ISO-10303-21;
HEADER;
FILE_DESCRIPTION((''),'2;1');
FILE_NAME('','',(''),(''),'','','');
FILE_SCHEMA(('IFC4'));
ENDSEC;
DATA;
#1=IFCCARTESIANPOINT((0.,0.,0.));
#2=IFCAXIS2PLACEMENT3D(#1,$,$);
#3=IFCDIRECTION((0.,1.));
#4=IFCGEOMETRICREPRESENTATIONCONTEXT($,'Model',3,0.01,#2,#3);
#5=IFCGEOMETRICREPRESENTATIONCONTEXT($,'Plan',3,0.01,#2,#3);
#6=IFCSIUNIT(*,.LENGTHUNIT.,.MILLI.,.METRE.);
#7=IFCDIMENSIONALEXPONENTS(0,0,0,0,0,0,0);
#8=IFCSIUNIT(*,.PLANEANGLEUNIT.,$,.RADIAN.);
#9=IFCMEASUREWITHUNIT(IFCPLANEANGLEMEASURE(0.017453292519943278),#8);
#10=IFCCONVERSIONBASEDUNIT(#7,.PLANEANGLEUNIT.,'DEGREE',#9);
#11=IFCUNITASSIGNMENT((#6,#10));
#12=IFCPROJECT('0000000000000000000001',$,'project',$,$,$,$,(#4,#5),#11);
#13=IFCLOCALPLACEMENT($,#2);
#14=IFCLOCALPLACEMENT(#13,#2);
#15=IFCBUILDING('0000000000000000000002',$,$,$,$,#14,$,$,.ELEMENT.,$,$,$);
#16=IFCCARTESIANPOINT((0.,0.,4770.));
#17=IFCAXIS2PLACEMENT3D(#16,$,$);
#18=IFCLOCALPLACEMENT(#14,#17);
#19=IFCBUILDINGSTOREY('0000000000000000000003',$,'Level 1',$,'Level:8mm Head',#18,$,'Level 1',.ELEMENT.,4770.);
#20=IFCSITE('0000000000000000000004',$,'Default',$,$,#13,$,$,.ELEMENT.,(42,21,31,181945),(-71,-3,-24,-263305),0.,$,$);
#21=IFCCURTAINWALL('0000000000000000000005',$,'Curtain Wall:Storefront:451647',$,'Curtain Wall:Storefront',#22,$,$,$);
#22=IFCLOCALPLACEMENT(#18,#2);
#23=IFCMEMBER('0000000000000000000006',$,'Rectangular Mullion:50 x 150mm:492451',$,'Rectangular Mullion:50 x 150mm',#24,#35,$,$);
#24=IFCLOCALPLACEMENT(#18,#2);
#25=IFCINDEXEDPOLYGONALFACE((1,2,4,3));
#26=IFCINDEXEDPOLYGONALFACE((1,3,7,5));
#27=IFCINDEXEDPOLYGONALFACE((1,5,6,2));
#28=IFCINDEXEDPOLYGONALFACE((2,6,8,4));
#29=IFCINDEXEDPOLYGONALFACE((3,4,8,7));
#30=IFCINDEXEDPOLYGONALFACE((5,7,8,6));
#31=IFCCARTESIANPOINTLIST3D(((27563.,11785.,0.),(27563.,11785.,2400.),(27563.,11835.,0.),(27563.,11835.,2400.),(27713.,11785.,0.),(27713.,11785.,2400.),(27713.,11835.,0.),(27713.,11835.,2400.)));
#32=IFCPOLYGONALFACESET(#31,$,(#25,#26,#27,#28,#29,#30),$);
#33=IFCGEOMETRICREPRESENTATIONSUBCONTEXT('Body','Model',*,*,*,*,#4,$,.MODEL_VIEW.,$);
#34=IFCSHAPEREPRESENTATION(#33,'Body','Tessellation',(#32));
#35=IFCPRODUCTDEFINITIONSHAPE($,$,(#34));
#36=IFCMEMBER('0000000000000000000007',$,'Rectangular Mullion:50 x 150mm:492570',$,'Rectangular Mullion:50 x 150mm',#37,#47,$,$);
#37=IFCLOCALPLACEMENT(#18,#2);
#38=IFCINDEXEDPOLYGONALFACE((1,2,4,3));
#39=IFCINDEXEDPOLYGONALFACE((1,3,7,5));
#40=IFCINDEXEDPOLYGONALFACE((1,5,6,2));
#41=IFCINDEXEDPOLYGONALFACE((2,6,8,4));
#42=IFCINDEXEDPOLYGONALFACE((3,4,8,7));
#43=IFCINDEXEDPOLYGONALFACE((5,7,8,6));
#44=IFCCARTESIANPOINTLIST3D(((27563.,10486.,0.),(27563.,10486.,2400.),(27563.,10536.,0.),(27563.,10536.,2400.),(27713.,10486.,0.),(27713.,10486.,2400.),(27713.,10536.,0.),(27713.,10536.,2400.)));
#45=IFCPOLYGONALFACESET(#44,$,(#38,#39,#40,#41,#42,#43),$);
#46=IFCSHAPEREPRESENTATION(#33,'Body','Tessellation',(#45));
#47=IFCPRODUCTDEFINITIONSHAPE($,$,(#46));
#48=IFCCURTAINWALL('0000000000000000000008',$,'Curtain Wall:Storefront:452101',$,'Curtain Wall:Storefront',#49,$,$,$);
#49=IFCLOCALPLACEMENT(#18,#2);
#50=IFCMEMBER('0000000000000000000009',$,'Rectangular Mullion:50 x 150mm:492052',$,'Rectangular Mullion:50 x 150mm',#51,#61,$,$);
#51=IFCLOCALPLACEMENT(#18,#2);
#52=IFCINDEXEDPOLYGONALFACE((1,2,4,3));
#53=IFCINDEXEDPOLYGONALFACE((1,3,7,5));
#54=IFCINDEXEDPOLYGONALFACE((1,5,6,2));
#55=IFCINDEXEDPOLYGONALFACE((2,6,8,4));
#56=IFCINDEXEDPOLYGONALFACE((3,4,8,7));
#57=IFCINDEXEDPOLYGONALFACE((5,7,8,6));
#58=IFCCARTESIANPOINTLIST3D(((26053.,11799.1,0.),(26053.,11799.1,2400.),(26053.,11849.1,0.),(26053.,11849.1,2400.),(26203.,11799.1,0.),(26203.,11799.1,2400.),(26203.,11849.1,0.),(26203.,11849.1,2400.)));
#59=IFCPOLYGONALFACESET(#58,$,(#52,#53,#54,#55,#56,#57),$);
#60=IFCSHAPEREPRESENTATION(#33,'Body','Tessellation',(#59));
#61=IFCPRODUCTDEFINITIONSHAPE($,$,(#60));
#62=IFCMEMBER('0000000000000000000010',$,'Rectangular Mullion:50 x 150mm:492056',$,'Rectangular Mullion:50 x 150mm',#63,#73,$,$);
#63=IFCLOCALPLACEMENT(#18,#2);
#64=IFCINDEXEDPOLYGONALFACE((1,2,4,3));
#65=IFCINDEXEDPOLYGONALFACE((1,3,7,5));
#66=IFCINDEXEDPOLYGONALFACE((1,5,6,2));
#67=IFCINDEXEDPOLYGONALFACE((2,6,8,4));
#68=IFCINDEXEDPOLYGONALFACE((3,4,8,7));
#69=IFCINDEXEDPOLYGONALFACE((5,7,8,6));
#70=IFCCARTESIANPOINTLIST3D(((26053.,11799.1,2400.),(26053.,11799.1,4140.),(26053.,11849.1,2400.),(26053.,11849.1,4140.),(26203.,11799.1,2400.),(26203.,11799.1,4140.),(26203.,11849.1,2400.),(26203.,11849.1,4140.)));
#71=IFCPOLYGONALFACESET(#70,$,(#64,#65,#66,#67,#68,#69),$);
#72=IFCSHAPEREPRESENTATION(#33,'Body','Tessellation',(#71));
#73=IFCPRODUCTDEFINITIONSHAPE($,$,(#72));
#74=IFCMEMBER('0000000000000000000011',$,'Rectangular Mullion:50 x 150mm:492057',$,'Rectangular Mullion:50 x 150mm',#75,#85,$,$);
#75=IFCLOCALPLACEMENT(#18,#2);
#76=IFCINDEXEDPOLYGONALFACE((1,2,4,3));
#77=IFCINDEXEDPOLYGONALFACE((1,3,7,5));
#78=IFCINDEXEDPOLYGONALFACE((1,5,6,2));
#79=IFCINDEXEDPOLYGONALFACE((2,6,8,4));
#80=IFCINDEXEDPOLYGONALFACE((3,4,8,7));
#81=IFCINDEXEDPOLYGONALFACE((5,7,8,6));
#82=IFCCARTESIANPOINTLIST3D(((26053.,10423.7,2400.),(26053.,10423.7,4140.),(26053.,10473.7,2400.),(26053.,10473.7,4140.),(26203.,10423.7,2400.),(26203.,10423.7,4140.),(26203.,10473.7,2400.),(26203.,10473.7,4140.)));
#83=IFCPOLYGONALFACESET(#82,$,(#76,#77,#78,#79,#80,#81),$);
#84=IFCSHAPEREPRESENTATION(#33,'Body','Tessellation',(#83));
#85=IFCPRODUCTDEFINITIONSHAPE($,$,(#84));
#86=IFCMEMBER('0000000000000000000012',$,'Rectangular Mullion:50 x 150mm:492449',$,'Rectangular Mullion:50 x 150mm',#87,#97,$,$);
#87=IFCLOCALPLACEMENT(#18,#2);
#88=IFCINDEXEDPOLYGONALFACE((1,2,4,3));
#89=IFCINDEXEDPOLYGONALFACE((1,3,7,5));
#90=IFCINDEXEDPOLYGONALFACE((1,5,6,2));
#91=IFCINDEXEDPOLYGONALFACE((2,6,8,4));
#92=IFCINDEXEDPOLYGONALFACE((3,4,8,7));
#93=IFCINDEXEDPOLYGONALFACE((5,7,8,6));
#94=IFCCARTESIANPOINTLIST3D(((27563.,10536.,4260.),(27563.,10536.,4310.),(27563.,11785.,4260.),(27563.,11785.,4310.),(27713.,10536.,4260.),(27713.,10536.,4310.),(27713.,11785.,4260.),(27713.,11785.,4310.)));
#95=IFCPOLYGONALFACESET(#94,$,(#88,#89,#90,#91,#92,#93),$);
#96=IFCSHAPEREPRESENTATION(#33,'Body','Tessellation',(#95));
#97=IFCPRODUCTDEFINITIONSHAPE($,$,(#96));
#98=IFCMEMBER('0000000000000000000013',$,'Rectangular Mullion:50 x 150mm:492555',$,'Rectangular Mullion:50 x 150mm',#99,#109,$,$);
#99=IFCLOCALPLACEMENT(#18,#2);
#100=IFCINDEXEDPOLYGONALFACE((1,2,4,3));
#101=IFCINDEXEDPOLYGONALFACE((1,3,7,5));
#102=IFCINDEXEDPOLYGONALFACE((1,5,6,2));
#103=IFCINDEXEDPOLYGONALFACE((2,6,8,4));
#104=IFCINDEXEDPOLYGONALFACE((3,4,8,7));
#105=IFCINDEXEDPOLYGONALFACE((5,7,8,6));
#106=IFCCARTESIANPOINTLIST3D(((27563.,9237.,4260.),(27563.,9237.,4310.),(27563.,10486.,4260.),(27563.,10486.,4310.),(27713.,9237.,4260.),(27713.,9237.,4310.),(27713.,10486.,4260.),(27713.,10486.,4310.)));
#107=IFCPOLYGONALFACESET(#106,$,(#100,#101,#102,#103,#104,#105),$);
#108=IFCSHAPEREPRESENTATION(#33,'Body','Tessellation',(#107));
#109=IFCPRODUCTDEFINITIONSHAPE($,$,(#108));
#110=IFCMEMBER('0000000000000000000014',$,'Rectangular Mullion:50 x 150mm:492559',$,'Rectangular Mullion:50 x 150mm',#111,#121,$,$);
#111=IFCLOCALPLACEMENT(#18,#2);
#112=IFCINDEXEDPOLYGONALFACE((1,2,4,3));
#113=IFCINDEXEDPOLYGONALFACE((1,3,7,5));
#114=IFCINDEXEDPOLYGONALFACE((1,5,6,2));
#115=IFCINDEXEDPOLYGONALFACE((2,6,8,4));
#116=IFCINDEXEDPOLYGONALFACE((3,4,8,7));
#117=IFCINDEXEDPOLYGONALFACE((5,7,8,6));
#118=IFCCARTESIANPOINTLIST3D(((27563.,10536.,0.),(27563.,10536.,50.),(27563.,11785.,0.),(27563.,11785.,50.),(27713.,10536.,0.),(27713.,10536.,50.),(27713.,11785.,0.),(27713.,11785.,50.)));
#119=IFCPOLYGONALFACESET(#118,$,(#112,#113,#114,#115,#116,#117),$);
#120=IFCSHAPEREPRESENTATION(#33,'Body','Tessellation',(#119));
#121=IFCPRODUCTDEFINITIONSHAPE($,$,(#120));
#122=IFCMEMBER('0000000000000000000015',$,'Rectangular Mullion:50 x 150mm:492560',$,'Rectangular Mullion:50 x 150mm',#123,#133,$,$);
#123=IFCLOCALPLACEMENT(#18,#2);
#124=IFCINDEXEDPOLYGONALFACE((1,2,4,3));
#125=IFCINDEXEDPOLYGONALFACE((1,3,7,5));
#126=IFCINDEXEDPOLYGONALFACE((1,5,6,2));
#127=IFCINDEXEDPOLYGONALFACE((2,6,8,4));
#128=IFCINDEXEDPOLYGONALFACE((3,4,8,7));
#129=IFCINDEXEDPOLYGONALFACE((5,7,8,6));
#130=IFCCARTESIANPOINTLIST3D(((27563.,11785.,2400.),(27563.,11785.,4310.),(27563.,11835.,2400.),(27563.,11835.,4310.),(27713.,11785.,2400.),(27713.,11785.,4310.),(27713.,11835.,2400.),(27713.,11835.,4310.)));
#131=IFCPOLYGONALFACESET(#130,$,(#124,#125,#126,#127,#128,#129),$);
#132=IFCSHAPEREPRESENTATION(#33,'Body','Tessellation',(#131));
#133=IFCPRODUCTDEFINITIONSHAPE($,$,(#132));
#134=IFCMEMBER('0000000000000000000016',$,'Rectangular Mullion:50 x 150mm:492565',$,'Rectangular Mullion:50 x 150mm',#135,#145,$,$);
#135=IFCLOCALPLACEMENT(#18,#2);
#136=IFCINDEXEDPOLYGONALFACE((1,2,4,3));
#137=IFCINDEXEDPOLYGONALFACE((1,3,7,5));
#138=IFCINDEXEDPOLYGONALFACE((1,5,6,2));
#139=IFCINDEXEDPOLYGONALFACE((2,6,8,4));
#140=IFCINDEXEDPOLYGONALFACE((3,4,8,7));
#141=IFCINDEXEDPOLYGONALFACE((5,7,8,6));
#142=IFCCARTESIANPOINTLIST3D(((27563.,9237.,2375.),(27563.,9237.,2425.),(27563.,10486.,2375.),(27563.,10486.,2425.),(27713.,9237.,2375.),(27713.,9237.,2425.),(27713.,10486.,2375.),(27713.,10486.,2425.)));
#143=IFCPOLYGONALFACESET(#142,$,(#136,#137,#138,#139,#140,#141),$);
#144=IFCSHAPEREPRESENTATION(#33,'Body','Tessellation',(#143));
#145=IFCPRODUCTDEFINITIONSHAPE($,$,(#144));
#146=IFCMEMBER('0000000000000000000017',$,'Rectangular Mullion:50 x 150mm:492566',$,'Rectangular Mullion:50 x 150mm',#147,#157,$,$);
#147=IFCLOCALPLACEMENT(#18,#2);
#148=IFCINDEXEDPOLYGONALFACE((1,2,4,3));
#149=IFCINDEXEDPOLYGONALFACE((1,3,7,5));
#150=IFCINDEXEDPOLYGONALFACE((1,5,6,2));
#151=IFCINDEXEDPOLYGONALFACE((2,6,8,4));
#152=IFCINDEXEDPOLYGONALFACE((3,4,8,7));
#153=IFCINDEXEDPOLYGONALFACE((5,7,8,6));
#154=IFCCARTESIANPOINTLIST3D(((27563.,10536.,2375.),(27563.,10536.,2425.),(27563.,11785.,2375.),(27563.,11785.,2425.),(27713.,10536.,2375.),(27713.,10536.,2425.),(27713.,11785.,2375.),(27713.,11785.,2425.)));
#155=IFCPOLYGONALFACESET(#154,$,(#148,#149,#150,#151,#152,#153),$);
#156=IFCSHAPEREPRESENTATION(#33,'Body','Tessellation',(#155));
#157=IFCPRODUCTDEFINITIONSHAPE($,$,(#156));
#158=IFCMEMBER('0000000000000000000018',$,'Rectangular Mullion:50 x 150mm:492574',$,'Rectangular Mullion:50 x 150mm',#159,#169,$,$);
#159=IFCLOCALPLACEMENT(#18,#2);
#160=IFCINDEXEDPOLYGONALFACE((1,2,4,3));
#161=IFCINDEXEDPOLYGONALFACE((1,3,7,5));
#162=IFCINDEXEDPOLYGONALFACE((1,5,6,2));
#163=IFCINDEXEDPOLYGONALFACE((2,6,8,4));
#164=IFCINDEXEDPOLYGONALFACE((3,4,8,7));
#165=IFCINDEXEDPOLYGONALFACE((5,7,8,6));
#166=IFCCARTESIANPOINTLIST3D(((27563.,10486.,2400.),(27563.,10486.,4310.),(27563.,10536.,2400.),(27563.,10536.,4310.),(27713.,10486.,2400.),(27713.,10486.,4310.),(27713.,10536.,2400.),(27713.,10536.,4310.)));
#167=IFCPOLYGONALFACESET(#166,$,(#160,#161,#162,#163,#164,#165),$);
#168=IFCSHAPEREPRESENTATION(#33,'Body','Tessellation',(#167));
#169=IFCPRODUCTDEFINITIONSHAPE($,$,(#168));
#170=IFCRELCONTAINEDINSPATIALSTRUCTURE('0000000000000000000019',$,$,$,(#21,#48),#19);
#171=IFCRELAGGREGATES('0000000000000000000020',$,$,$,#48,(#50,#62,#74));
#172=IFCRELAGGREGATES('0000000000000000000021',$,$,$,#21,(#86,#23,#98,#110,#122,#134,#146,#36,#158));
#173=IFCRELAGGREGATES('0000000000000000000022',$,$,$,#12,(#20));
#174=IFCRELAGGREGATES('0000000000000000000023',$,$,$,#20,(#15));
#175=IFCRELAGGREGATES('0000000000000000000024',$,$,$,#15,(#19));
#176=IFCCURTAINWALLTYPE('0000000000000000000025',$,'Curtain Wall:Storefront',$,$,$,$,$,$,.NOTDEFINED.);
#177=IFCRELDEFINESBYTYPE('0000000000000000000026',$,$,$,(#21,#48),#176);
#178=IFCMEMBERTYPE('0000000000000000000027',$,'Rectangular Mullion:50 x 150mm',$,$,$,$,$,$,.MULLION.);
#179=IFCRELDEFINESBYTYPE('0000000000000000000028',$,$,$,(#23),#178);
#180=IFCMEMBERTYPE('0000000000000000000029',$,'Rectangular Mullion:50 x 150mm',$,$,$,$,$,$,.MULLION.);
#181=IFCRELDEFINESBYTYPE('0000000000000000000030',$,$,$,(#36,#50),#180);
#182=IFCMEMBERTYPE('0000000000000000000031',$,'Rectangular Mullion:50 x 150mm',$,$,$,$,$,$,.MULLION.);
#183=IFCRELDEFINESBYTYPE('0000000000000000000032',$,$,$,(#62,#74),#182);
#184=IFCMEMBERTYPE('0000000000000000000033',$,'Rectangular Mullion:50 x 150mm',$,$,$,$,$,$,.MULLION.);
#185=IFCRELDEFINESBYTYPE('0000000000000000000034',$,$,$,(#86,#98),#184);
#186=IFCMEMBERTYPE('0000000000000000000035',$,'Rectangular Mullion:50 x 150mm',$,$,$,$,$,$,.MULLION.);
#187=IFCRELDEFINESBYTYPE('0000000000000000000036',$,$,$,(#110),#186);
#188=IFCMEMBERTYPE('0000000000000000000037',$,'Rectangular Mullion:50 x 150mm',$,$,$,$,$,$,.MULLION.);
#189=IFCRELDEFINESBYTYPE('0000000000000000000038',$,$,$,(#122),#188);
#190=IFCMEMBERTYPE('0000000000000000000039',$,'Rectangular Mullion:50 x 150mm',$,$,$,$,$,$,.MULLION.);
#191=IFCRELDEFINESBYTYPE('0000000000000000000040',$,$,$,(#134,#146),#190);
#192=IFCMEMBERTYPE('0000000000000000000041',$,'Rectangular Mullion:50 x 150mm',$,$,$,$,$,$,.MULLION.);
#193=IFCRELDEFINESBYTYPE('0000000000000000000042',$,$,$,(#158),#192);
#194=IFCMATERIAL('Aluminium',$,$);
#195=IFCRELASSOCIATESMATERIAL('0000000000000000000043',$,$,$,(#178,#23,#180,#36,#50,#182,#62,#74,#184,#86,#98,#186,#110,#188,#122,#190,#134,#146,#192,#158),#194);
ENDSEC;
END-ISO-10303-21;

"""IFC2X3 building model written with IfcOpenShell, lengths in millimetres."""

from ifc_helpers import new_model, entity, si_unit, converted_unit, direction, frame, origin, origin_2d_with_axis, place, context, subcontext, project, spatial, rectangle, extrude, source, transform, mapped, material, type_object, type_shapes, element, aggregate, save


model = new_model("IFC2X3")

# Units and contexts
model_context = context("Model", 3, precision=0.01, world=origin(), true_north=direction((0.0, 1.0)))
plan_context = context("Plan", 3, precision=0.01, world=origin(), true_north=direction((0.0, 1.0)))
body_context = subcontext(model_context, "Body", "Model", "MODEL_VIEW")
ifc_project = project(units=[si_unit("LENGTHUNIT", "METRE", prefix="MILLI"), converted_unit("PLANEANGLEUNIT", "DEGREE", entity("IfcPlaneAngleMeasure", 0.017453292519943278), si_unit("PLANEANGLEUNIT", "RADIAN"), dimensions=[0, 0, 0, 0, 0, 0, 0])], contexts=[model_context, plan_context])

# Site, building, storey
site_placement = place(None, origin())
site = spatial("IfcSite", under=ifc_project, at=site_placement, Name="Default", CompositionType="ELEMENT", RefLatitude=(42, 21, 31, 181945), RefLongitude=(-71, -3, -24, -263305), RefElevation=0.0)
building_placement = place(site_placement, origin())
building = spatial("IfcBuilding", under=site, at=building_placement, CompositionType="ELEMENT")
storey_placement = place(building_placement, frame((0.0, 0.0, 4770.0)))
storey = spatial("IfcBuildingStorey", under=building, at=storey_placement, Name="Level 1", ObjectType="Level:8mm Head", LongName="Level 1", CompositionType="ELEMENT", Elevation=4770.0)

# Curtain walls, members
curtain_wall_type = type_object("IfcCurtainWallType", Name="Curtain Wall:Storefront", PredefinedType="NOTDEFINED")
curtain_wall_1_placement = place(storey_placement, frame((0.0, 0.0, -4770.0)))
curtain_wall_1 = element("IfcCurtainWall", 1, at=curtain_wall_1_placement, inside=storey, type_object=curtain_wall_type, Name="Curtain Wall:Storefront:451647", ObjectType="Curtain Wall:Storefront")
ifc_material_1 = material(Name="Aluminium")
member_type_1 = type_object("IfcMemberType", Name="Rectangular Mullion:50 x 150mm", PredefinedType="MULLION", material=ifc_material_1)
shared_shape_1 = source(origin(), body_context, "Body", "SweptSolid", [
    extrude(rectangle(XDim=50.0, YDim=150.0, at=origin_2d_with_axis()), frame((-25.0, 0.0, -2400.0), z_axis=(0.0, 0.0, 1.0), x_axis=(-1.0, 0.0, 0.0)), (0.0, 0.0, 1.0), 2400.0),
])
type_shapes(member_type_1, [shared_shape_1])
member_1_placement = place(curtain_wall_1_placement, frame((27638.0, 11835.0, 4770.0), z_axis=(0.0, 0.0, -1.0), x_axis=(0.0, 1.0, 0.0)))
member_1 = element("IfcMember", 2, at=member_1_placement, type_object=member_type_1, material=ifc_material_1, Name="Rectangular Mullion:50 x 150mm:492451", ObjectType="Rectangular Mullion:50 x 150mm", context=body_context, shape_type="MappedRepresentation", body=[
    mapped(shared_shape_1, transform((0.0, 0.0, 0.0), scale=1.0)),
])
member_type_2 = type_object("IfcMemberType", Name="Rectangular Mullion:50 x 150mm", PredefinedType="MULLION", material=ifc_material_1)
shared_shape_2 = source(origin(), body_context, "Body", "SweptSolid", [
    extrude(rectangle(XDim=50.0, YDim=150.0, at=origin_2d_with_axis()), frame((0.0, 0.0, -2400.0), z_axis=(0.0, 0.0, 1.0), x_axis=(-1.0, 0.0, 0.0)), (0.0, 0.0, 1.0), 2400.0),
])
type_shapes(member_type_2, [shared_shape_2])
member_2_placement = place(curtain_wall_1_placement, frame((27638.0, 10511.0, 4770.0), z_axis=(0.0, 0.0, -1.0), x_axis=(0.0, 1.0, 0.0)))
member_2 = element("IfcMember", 3, at=member_2_placement, type_object=member_type_2, material=ifc_material_1, Name="Rectangular Mullion:50 x 150mm:492570", ObjectType="Rectangular Mullion:50 x 150mm", context=body_context, shape_type="MappedRepresentation", body=[
    mapped(shared_shape_2, transform((0.0, 0.0, 0.0), scale=1.0)),
])
curtain_wall_2_placement = place(storey_placement, frame((0.0, 0.0, -4770.0)))
curtain_wall_2 = element("IfcCurtainWall", 4, at=curtain_wall_2_placement, inside=storey, type_object=curtain_wall_type, Name="Curtain Wall:Storefront:452101", ObjectType="Curtain Wall:Storefront")
member_3_placement = place(curtain_wall_2_placement, frame((26128.0, 11824.1, 4770.0), z_axis=(0.0, 0.0, -1.0), x_axis=(0.0, -1.0, 0.0)))
member_3 = element("IfcMember", 5, at=member_3_placement, type_object=member_type_2, material=ifc_material_1, Name="Rectangular Mullion:50 x 150mm:492052", ObjectType="Rectangular Mullion:50 x 150mm", context=body_context, shape_type="MappedRepresentation", body=[
    mapped(shared_shape_2, transform((0.0, 0.0, 0.0), scale=1.0)),
])
member_type_3 = type_object("IfcMemberType", Name="Rectangular Mullion:50 x 150mm", PredefinedType="MULLION", material=ifc_material_1)
shared_shape_3 = source(origin(), body_context, "Body", "SweptSolid", [
    extrude(rectangle(XDim=50.0, YDim=150.0, at=origin_2d_with_axis()), frame((0.0, 0.0, -1740.0), z_axis=(0.0, 0.0, 1.0), x_axis=(-1.0, 0.0, 0.0)), (0.0, 0.0, 1.0), 1740.0),
])
type_shapes(member_type_3, [shared_shape_3])
member_4_placement = place(curtain_wall_2_placement, frame((26128.0, 11824.1, 7170.0), z_axis=(0.0, 0.0, -1.0), x_axis=(0.0, -1.0, 0.0)))
member_4 = element("IfcMember", 6, at=member_4_placement, type_object=member_type_3, material=ifc_material_1, Name="Rectangular Mullion:50 x 150mm:492056", ObjectType="Rectangular Mullion:50 x 150mm", context=body_context, shape_type="MappedRepresentation", body=[
    mapped(shared_shape_3, transform((0.0, 0.0, 0.0), scale=1.0)),
])
member_5_placement = place(curtain_wall_2_placement, frame((26128.0, 10448.7, 7170.0), z_axis=(0.0, 0.0, -1.0), x_axis=(0.0, -1.0, 0.0)))
member_5 = element("IfcMember", 7, at=member_5_placement, type_object=member_type_3, material=ifc_material_1, Name="Rectangular Mullion:50 x 150mm:492057", ObjectType="Rectangular Mullion:50 x 150mm", context=body_context, shape_type="MappedRepresentation", body=[
    mapped(shared_shape_3, transform((0.0, 0.0, 0.0), scale=1.0)),
])

# Members
member_type_4 = type_object("IfcMemberType", Name="Rectangular Mullion:50 x 150mm", PredefinedType="MULLION", material=ifc_material_1)
shared_shape_4 = source(origin(), body_context, "Body", "SweptSolid", [
    extrude(rectangle(XDim=50.0, YDim=150.0, at=origin_2d_with_axis()), frame((-25.0, 0.0, -1249.0), z_axis=(0.0, 0.0, 1.0), x_axis=(-1.0, 0.0, 0.0)), (0.0, 0.0, 1.0), 1249.0),
])
type_shapes(member_type_4, [shared_shape_4])
member_6_placement = place(curtain_wall_1_placement, frame((27638.0, 11785.0, 9080.0), z_axis=(0.0, 1.0, 0.0), x_axis=(0.0, 0.0, 1.0)))
member_6 = element("IfcMember", 8, at=member_6_placement, type_object=member_type_4, material=ifc_material_1, Name="Rectangular Mullion:50 x 150mm:492449", ObjectType="Rectangular Mullion:50 x 150mm", context=body_context, shape_type="MappedRepresentation", body=[
    mapped(shared_shape_4, transform((0.0, 0.0, 0.0), scale=1.0)),
])
member_7_placement = place(curtain_wall_1_placement, frame((27638.0, 10486.0, 9080.0), z_axis=(0.0, 1.0, 0.0), x_axis=(0.0, 0.0, 1.0)))
member_7 = element("IfcMember", 9, at=member_7_placement, type_object=member_type_4, material=ifc_material_1, Name="Rectangular Mullion:50 x 150mm:492555", ObjectType="Rectangular Mullion:50 x 150mm", context=body_context, shape_type="MappedRepresentation", body=[
    mapped(shared_shape_4, transform((0.0, 0.0, 0.0), scale=1.0)),
])
member_type_5 = type_object("IfcMemberType", Name="Rectangular Mullion:50 x 150mm", PredefinedType="MULLION", material=ifc_material_1)
shared_shape_5 = source(origin(), body_context, "Body", "SweptSolid", [
    extrude(rectangle(XDim=50.0, YDim=150.0, at=origin_2d_with_axis()), frame((-25.0, 0.0, -1249.0), z_axis=(0.0, 0.0, 1.0), x_axis=(-1.0, 0.0, 0.0)), (0.0, 0.0, 1.0), 1249.0),
])
type_shapes(member_type_5, [shared_shape_5])
member_8_placement = place(curtain_wall_1_placement, frame((27638.0, 10536.0, 4770.0), z_axis=(0.0, -1.0, 0.0), x_axis=(0.0, 0.0, -1.0)))
member_8 = element("IfcMember", 10, at=member_8_placement, type_object=member_type_5, material=ifc_material_1, Name="Rectangular Mullion:50 x 150mm:492559", ObjectType="Rectangular Mullion:50 x 150mm", context=body_context, shape_type="MappedRepresentation", body=[
    mapped(shared_shape_5, transform((0.0, 0.0, 0.0), scale=1.0)),
])
member_type_6 = type_object("IfcMemberType", Name="Rectangular Mullion:50 x 150mm", PredefinedType="MULLION", material=ifc_material_1)
shared_shape_6 = source(origin(), body_context, "Body", "SweptSolid", [
    extrude(rectangle(XDim=50.0, YDim=150.0, at=origin_2d_with_axis()), frame((-25.0, 0.0, -1910.0), z_axis=(0.0, 0.0, 1.0), x_axis=(-1.0, 0.0, 0.0)), (0.0, 0.0, 1.0), 1910.0),
])
type_shapes(member_type_6, [shared_shape_6])
member_9_placement = place(curtain_wall_1_placement, frame((27638.0, 11835.0, 7170.0), z_axis=(0.0, 0.0, -1.0), x_axis=(0.0, 1.0, 0.0)))
member_9 = element("IfcMember", 11, at=member_9_placement, type_object=member_type_6, material=ifc_material_1, Name="Rectangular Mullion:50 x 150mm:492560", ObjectType="Rectangular Mullion:50 x 150mm", context=body_context, shape_type="MappedRepresentation", body=[
    mapped(shared_shape_6, transform((0.0, 0.0, 0.0), scale=1.0)),
])
member_type_7 = type_object("IfcMemberType", Name="Rectangular Mullion:50 x 150mm", PredefinedType="MULLION", material=ifc_material_1)
shared_shape_7 = source(origin(), body_context, "Body", "SweptSolid", [
    extrude(rectangle(XDim=50.0, YDim=150.0, at=origin_2d_with_axis()), frame((0.0, 0.0, -1249.0), z_axis=(0.0, 0.0, 1.0), x_axis=(-1.0, 0.0, 0.0)), (0.0, 0.0, 1.0), 1249.0),
])
type_shapes(member_type_7, [shared_shape_7])
member_10_placement = place(curtain_wall_1_placement, frame((27638.0, 10486.0, 7170.0), z_axis=(0.0, 1.0, 0.0), x_axis=(0.0, 0.0, 1.0)))
member_10 = element("IfcMember", 12, at=member_10_placement, type_object=member_type_7, material=ifc_material_1, Name="Rectangular Mullion:50 x 150mm:492565", ObjectType="Rectangular Mullion:50 x 150mm", context=body_context, shape_type="MappedRepresentation", body=[
    mapped(shared_shape_7, transform((0.0, 0.0, 0.0), scale=1.0)),
])
member_11_placement = place(curtain_wall_1_placement, frame((27638.0, 11785.0, 7170.0), z_axis=(0.0, 1.0, 0.0), x_axis=(0.0, 0.0, 1.0)))
member_11 = element("IfcMember", 13, at=member_11_placement, type_object=member_type_7, material=ifc_material_1, Name="Rectangular Mullion:50 x 150mm:492566", ObjectType="Rectangular Mullion:50 x 150mm", context=body_context, shape_type="MappedRepresentation", body=[
    mapped(shared_shape_7, transform((0.0, 0.0, 0.0), scale=1.0)),
])
member_type_8 = type_object("IfcMemberType", Name="Rectangular Mullion:50 x 150mm", PredefinedType="MULLION", material=ifc_material_1)
shared_shape_8 = source(origin(), body_context, "Body", "SweptSolid", [
    extrude(rectangle(XDim=50.0, YDim=150.0, at=origin_2d_with_axis()), frame((0.0, 0.0, -1910.0), z_axis=(0.0, 0.0, 1.0), x_axis=(-1.0, 0.0, 0.0)), (0.0, 0.0, 1.0), 1910.0),
])
type_shapes(member_type_8, [shared_shape_8])
member_12_placement = place(curtain_wall_1_placement, frame((27638.0, 10511.0, 7170.0), z_axis=(0.0, 0.0, -1.0), x_axis=(0.0, 1.0, 0.0)))
member_12 = element("IfcMember", 14, at=member_12_placement, type_object=member_type_8, material=ifc_material_1, Name="Rectangular Mullion:50 x 150mm:492574", ObjectType="Rectangular Mullion:50 x 150mm", context=body_context, shape_type="MappedRepresentation", body=[
    mapped(shared_shape_8, transform((0.0, 0.0, 0.0), scale=1.0)),
])

aggregate(curtain_wall_2, [member_3, member_4, member_5])

aggregate(curtain_wall_1, [member_6, member_1, member_7, member_8, member_9, member_10, member_11, member_2, member_12])

save(model, "model.ifc")
